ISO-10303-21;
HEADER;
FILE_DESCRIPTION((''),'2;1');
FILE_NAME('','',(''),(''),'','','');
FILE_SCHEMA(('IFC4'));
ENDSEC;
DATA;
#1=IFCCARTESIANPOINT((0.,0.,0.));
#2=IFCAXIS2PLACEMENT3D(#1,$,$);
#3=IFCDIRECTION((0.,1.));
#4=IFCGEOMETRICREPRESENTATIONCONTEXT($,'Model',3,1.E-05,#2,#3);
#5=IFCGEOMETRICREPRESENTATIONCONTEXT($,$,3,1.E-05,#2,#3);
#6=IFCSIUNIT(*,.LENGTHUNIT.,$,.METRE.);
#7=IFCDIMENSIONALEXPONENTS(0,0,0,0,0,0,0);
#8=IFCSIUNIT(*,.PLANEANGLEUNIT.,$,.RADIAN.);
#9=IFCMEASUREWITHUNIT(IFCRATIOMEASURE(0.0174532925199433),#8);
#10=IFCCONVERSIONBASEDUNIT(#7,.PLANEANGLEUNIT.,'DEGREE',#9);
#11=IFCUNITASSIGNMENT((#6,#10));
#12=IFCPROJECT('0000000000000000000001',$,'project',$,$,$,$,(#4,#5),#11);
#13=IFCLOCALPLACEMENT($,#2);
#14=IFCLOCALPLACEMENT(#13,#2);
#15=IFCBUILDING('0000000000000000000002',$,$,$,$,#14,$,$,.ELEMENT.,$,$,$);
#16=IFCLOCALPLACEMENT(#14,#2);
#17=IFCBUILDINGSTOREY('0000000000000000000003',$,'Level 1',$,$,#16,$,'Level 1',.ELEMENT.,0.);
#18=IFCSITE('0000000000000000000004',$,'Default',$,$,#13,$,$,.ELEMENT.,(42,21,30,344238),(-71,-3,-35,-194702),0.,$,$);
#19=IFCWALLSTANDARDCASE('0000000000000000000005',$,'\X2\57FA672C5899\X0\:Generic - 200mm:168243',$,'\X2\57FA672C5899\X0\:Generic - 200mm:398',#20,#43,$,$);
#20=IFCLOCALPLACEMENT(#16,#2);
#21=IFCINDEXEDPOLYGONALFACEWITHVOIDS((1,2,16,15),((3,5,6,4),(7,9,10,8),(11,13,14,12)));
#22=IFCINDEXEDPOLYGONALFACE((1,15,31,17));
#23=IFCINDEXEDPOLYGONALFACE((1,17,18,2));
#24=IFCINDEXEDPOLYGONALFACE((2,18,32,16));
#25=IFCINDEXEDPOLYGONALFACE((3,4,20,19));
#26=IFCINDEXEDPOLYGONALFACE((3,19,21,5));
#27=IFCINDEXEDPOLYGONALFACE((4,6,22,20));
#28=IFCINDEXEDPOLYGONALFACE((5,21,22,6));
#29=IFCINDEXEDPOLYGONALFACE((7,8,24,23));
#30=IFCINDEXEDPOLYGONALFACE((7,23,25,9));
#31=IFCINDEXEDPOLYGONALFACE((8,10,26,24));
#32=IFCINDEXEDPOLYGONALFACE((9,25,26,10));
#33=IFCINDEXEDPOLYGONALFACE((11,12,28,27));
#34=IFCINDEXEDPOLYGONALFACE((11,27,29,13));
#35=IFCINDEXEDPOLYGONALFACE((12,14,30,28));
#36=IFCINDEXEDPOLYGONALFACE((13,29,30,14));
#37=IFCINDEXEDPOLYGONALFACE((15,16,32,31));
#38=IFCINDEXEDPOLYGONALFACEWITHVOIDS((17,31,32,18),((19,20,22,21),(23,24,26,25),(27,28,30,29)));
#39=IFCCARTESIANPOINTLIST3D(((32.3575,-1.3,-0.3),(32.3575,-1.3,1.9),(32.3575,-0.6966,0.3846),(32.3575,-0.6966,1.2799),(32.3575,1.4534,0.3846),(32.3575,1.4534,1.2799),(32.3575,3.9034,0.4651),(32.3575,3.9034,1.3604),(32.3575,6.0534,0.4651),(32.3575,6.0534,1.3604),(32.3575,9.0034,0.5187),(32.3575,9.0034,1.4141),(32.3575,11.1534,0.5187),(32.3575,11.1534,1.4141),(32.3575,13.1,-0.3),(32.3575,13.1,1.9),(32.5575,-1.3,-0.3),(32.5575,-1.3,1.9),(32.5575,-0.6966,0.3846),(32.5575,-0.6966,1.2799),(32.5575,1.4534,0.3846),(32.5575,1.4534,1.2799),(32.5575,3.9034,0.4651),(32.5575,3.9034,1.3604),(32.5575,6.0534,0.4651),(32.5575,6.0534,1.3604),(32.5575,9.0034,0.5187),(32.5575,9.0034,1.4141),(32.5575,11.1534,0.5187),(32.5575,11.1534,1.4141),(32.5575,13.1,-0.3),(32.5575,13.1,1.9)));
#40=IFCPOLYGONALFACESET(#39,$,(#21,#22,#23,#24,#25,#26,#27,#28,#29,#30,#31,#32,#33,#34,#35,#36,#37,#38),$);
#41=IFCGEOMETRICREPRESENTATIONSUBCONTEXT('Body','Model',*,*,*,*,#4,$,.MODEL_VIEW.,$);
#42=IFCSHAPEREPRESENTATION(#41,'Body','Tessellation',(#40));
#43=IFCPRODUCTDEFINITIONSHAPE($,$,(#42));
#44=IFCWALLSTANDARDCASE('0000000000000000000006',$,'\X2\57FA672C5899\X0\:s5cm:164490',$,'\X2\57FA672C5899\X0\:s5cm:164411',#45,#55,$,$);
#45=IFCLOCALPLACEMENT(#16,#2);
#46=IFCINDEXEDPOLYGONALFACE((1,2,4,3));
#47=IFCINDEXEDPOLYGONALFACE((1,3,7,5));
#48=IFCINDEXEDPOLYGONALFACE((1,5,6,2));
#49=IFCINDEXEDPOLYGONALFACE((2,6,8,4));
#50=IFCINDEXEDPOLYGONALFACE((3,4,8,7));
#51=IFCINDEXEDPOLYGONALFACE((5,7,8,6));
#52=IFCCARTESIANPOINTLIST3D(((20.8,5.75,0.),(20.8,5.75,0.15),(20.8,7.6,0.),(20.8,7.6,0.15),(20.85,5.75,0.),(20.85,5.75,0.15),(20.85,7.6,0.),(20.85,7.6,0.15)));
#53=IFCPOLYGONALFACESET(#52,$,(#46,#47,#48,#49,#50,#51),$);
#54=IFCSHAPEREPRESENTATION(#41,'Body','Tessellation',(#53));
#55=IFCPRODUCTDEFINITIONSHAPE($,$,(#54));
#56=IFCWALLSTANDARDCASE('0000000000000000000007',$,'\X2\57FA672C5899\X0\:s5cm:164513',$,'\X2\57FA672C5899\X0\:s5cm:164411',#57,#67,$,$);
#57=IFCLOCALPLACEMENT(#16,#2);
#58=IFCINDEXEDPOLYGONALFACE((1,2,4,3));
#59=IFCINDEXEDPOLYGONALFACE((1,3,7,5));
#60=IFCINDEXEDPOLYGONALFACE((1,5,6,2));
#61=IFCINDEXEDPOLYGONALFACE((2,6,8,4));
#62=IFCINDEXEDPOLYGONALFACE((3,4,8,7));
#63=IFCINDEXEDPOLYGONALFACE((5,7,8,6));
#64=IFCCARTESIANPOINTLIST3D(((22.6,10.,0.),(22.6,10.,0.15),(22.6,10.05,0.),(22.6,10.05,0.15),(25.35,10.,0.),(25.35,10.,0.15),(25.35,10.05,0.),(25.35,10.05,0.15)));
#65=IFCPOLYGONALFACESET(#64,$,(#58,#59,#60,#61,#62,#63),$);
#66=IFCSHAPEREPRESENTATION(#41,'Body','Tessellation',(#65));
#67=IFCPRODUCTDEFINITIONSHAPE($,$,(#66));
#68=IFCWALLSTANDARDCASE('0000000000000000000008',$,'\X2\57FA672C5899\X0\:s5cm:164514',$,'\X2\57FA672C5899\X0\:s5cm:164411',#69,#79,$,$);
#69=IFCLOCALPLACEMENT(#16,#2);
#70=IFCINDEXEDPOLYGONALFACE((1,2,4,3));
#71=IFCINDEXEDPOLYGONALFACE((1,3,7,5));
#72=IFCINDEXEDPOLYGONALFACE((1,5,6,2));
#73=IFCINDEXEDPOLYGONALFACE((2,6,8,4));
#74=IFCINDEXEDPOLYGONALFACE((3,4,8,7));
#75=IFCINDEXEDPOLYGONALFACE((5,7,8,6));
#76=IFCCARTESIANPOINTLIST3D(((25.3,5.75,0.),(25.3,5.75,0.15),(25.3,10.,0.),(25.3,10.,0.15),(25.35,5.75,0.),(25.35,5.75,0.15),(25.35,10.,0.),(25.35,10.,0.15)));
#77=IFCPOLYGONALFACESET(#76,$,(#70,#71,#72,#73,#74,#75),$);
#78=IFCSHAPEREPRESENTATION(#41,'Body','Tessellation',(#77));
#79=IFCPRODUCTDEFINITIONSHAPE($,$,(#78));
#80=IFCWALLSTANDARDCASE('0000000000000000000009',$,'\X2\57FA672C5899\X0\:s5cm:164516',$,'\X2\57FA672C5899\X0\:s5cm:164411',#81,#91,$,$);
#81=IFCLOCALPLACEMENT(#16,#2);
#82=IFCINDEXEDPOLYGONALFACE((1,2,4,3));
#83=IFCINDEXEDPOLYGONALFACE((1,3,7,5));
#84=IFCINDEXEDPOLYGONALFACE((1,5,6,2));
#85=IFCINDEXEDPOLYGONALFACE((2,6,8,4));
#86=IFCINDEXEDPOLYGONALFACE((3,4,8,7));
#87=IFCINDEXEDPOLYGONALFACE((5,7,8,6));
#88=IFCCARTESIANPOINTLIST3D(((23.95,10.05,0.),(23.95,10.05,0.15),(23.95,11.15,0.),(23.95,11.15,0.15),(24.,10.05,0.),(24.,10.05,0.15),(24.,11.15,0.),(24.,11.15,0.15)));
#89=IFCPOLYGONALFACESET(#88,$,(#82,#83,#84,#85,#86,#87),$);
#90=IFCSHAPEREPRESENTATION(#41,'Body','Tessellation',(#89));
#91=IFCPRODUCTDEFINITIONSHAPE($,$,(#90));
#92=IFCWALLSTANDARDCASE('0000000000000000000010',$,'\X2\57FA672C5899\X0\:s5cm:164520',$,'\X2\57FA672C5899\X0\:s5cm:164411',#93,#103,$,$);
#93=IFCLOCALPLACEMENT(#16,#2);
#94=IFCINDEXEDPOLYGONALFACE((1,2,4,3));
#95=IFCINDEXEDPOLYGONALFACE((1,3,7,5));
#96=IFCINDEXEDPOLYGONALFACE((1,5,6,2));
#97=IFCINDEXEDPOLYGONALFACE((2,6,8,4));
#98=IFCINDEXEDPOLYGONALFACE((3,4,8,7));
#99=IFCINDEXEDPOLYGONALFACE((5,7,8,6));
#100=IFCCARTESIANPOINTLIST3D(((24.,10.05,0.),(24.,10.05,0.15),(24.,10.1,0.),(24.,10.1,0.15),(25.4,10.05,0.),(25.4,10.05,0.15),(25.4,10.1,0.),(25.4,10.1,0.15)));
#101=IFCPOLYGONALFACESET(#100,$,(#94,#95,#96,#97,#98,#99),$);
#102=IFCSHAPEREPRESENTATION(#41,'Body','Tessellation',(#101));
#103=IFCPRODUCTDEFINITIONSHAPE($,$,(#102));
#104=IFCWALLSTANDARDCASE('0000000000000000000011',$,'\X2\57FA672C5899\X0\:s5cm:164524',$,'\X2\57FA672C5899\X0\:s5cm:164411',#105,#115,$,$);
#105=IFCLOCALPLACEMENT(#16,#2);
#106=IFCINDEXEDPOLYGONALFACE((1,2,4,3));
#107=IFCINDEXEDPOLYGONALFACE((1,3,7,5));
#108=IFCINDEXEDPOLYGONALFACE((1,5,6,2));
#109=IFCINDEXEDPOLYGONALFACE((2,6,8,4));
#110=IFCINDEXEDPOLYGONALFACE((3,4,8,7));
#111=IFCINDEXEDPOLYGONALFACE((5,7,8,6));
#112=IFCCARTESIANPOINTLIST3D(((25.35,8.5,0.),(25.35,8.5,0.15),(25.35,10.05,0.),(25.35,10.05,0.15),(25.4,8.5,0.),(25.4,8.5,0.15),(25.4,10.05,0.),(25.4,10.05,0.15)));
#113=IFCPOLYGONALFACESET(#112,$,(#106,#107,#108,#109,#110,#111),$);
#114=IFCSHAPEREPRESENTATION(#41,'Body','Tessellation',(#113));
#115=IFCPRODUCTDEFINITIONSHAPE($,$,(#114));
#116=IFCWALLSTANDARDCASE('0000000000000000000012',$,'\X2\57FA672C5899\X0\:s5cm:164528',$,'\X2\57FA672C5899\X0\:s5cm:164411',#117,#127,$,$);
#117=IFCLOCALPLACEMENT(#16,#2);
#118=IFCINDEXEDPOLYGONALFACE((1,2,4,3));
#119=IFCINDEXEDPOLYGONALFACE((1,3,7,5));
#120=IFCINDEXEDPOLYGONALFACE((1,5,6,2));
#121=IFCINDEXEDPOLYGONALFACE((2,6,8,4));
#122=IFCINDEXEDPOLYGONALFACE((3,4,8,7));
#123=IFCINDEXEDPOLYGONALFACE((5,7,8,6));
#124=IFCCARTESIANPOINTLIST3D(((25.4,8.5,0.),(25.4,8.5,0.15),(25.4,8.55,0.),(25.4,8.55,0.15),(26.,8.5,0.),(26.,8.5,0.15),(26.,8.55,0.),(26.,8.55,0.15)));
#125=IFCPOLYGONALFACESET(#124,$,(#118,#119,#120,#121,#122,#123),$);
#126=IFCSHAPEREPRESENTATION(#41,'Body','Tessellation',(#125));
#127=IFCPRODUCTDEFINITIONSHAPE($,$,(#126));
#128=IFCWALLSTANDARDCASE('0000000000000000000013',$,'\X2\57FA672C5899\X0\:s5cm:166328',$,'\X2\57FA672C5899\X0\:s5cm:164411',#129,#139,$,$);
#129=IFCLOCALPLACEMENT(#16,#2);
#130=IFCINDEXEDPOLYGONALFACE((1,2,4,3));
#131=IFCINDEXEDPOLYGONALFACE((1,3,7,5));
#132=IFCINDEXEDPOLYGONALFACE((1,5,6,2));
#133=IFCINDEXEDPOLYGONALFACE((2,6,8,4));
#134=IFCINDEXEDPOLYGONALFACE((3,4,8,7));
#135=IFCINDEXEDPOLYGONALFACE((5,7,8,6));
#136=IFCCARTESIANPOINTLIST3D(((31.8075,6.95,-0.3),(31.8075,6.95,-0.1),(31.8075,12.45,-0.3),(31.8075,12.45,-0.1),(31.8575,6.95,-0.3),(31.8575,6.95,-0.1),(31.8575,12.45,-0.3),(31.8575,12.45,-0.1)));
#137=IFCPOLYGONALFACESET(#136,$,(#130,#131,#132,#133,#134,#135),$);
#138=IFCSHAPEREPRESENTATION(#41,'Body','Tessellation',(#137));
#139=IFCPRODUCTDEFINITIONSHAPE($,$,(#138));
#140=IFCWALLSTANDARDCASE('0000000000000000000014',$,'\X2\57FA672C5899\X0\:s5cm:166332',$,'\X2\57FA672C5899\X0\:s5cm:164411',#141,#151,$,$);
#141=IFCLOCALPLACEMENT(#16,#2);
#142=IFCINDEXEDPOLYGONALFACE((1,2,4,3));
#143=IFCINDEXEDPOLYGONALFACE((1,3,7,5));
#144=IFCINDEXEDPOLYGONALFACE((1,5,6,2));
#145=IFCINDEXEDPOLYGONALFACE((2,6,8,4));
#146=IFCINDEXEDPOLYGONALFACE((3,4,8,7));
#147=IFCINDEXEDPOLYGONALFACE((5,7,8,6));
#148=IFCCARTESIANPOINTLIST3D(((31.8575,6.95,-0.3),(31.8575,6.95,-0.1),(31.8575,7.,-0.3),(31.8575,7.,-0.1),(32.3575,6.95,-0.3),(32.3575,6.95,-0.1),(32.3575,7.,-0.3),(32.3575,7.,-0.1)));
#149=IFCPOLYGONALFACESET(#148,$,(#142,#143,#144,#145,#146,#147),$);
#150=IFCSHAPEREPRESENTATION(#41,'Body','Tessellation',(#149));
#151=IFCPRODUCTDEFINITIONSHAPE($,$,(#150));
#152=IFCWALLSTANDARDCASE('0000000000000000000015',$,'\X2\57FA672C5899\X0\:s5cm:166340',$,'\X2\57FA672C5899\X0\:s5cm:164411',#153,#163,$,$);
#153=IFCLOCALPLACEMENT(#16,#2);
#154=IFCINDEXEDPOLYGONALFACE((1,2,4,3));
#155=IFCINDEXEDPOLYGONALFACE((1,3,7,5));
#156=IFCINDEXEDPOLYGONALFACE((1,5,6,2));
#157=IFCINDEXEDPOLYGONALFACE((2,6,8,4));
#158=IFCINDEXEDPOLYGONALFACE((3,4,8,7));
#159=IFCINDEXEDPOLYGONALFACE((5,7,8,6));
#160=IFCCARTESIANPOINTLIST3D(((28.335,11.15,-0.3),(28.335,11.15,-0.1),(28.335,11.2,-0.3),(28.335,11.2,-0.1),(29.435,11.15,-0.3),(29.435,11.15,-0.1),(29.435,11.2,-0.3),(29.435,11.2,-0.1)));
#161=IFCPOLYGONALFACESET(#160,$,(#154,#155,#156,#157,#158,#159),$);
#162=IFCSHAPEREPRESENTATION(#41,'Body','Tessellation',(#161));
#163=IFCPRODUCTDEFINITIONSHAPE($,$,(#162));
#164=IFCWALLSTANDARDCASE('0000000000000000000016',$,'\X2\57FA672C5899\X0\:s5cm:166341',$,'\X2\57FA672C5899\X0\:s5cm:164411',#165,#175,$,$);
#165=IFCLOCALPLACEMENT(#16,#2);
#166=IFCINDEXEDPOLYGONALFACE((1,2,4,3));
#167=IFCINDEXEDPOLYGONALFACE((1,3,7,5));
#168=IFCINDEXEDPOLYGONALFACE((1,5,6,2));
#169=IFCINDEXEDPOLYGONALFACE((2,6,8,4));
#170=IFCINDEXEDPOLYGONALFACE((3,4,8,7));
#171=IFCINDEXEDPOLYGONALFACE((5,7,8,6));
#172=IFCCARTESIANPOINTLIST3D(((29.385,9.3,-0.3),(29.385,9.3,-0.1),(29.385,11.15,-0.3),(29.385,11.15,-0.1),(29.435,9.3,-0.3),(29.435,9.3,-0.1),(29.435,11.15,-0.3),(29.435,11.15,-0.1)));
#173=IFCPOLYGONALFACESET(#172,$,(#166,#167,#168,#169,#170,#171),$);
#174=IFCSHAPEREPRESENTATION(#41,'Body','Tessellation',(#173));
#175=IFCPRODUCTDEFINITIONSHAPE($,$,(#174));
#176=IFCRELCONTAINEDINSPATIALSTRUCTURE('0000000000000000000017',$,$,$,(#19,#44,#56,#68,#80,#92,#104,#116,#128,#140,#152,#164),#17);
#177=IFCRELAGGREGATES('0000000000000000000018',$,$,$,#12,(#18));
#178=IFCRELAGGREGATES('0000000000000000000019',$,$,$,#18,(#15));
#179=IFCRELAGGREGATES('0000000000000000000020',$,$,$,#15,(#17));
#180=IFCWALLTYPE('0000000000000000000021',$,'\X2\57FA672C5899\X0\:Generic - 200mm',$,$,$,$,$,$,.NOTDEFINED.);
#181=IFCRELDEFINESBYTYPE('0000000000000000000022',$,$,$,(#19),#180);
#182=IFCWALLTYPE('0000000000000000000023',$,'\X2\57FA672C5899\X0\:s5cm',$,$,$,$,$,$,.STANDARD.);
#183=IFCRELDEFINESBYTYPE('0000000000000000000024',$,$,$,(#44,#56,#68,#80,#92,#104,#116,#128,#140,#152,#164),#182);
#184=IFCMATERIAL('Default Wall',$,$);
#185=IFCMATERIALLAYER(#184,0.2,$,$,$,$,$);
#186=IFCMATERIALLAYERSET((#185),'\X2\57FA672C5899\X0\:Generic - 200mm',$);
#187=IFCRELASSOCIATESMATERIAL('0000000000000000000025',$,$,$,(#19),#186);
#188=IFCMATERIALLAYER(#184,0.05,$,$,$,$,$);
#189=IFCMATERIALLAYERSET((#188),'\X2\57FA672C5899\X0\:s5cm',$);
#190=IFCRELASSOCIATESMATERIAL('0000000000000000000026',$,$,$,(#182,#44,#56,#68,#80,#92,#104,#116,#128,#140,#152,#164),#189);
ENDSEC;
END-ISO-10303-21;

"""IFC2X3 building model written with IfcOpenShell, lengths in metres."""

from ifc_helpers import new_model, entity, si_unit, converted_unit, direction, frame, frame_2d, origin, place, context, subcontext, project, spatial, rectangle, extrude, material, layer, layer_set, layer_usage, type_object, element, save


model = new_model("IFC2X3")

# Units and contexts
model_context = context("Model", 3, precision=1e-05, world=origin(), true_north=direction((0.0, 1.0)))
context_of_model = context(None, 3, precision=1e-05, world=origin(), true_north=direction((0.0, 1.0)))
body_context = subcontext(model_context, "Body", "Model", "MODEL_VIEW")
ifc_project = project(units=[si_unit("LENGTHUNIT", "METRE"), converted_unit("PLANEANGLEUNIT", "DEGREE", entity("IfcRatioMeasure", 0.0174532925199433), si_unit("PLANEANGLEUNIT", "RADIAN"), dimensions=[0, 0, 0, 0, 0, 0, 0])], contexts=[model_context, context_of_model])

# Site, building, storey
site_placement = place(None, origin())
site = spatial("IfcSite", under=ifc_project, at=site_placement, Name="Default", CompositionType="ELEMENT", RefLatitude=(42, 21, 30, 344238), RefLongitude=(-71, -3, -35, -194702), RefElevation=0.0)
building_placement = place(site_placement, origin())
building = spatial("IfcBuilding", under=site, at=building_placement, CompositionType="ELEMENT")
storey_placement = place(building_placement, origin())
storey = spatial("IfcBuildingStorey", under=building, at=storey_placement, Name="Level 1", LongName="Level 1", CompositionType="ELEMENT", Elevation=0.0)

# Wall, openings
ifc_material = material(Name="Default Wall")
ifc_layer_1 = layer(ifc_material, 0.2)
ifc_layer_set_1 = layer_set([ifc_layer_1], Name="基本墙:Generic - 200mm")
ifc_layer_usage_1 = layer_usage(ifc_layer_set_1, "AXIS2", "NEGATIVE", 0.1)
wall_type_1 = type_object("IfcWallType", Name="基本墙:Generic - 200mm", PredefinedType="NOTDEFINED")
wall_1_placement = place(storey_placement, frame((32.4575, 13.1, -0.3), z_axis=(0.0, 0.0, 1.0), x_axis=(0.0, -1.0, 0.0)))
wall_1 = element("IfcWallStandardCase", 1, at=wall_1_placement, inside=storey, type_object=wall_type_1, material=ifc_layer_usage_1, Name="基本墙:Generic - 200mm:168243", ObjectType="基本墙:Generic - 200mm:398", context=body_context, shape_type="SweptSolid", body=[
    extrude(rectangle(XDim=14.4, YDim=0.2, at=frame_2d((7.2, 0.0), x_axis=(-1.0, 0.0))), origin(), (0.0, 0.0, 1.0), 2.2),
])
opening_1_placement = place(wall_1_placement, frame((13.7966, -0.2048, 0.6846)))
element("IfcOpeningElement", 2, at=opening_1_placement, cuts=wall_1, ObjectType="Opening", context=body_context, shape_type="SweptSolid", body=[
    extrude(rectangle(XDim=0.8953, YDim=2.15, at=frame_2d((0.0, 0.0), x_axis=(0.0, 1.0))), frame((-1.075, 0.0, 0.4477), z_axis=(0.0, 1.0, 0.0), x_axis=(1.0, 0.0, 0.0)), (0.0, 0.0, 1.0), 0.3048),
])
opening_2_placement = place(wall_1_placement, frame((9.1966, -0.2048, 0.7651)))
element("IfcOpeningElement", 3, at=opening_2_placement, cuts=wall_1, ObjectType="Opening", context=body_context, shape_type="SweptSolid", body=[
    extrude(rectangle(XDim=0.8953, YDim=2.15, at=frame_2d((0.0, 0.0), x_axis=(0.0, 1.0))), frame((-1.075, 0.0, 0.4477), z_axis=(0.0, 1.0, 0.0), x_axis=(1.0, 0.0, 0.0)), (0.0, 0.0, 1.0), 0.3048),
])
opening_3_placement = place(wall_1_placement, frame((4.0966, -0.2048, 0.8187)))
element("IfcOpeningElement", 4, at=opening_3_placement, cuts=wall_1, ObjectType="Opening", context=body_context, shape_type="SweptSolid", body=[
    extrude(rectangle(XDim=0.8953, YDim=2.15, at=frame_2d((0.0, 0.0), x_axis=(0.0, 1.0))), frame((-1.075, 0.0, 0.4477), z_axis=(0.0, 1.0, 0.0), x_axis=(1.0, 0.0, 0.0)), (0.0, 0.0, 1.0), 0.3048),
])

# Walls
ifc_layer_2 = layer(ifc_material, 0.05)
ifc_layer_set_2 = layer_set([ifc_layer_2], Name="基本墙:s5cm")
ifc_layer_usage_2 = layer_usage(ifc_layer_set_2, "AXIS2", "NEGATIVE", 0.025)
wall_type_2 = type_object("IfcWallType", Name="基本墙:s5cm", PredefinedType="STANDARD", material=ifc_layer_set_2)
wall_2_placement = place(storey_placement, frame((20.825, 7.6, 0.0), z_axis=(0.0, 0.0, 1.0), x_axis=(0.0, -1.0, 0.0)))
element("IfcWallStandardCase", 5, at=wall_2_placement, inside=storey, type_object=wall_type_2, material=ifc_layer_usage_2, Name="基本墙:s5cm:164490", ObjectType="基本墙:s5cm:164411", context=body_context, shape_type="SweptSolid", body=[
    extrude(rectangle(XDim=1.85, YDim=0.05, at=frame_2d((0.925, 0.0), x_axis=(-1.0, 0.0))), origin(), (0.0, 0.0, 1.0), 0.15),
])
ifc_layer_usage_3 = layer_usage(ifc_layer_set_2, "AXIS2", "NEGATIVE", 0.025)
wall_3_placement = place(storey_placement, frame((22.6, 10.025, 0.0)))
element("IfcWallStandardCase", 6, at=wall_3_placement, inside=storey, type_object=wall_type_2, material=ifc_layer_usage_3, Name="基本墙:s5cm:164513", ObjectType="基本墙:s5cm:164411", context=body_context, shape_type="SweptSolid", body=[
    extrude(rectangle(XDim=2.75, YDim=0.05, at=frame_2d((1.375, 0.0), x_axis=(-1.0, 0.0))), origin(), (0.0, 0.0, 1.0), 0.15),
])
ifc_layer_usage_4 = layer_usage(ifc_layer_set_2, "AXIS2", "NEGATIVE", 0.025)
wall_4_placement = place(storey_placement, frame((25.325, 10.0, 0.0), z_axis=(0.0, 0.0, 1.0), x_axis=(0.0, -1.0, 0.0)))
element("IfcWallStandardCase", 7, at=wall_4_placement, inside=storey, type_object=wall_type_2, material=ifc_layer_usage_4, Name="基本墙:s5cm:164514", ObjectType="基本墙:s5cm:164411", context=body_context, shape_type="SweptSolid", body=[
    extrude(rectangle(XDim=4.25, YDim=0.05, at=frame_2d((2.125, 0.0), x_axis=(-1.0, 0.0))), origin(), (0.0, 0.0, 1.0), 0.15),
])
ifc_layer_usage_5 = layer_usage(ifc_layer_set_2, "AXIS2", "NEGATIVE", 0.025)
wall_5_placement = place(storey_placement, frame((23.975, 10.05, 0.0), z_axis=(0.0, 0.0, 1.0), x_axis=(0.0, 1.0, 0.0)))
element("IfcWallStandardCase", 8, at=wall_5_placement, inside=storey, type_object=wall_type_2, material=ifc_layer_usage_5, Name="基本墙:s5cm:164516", ObjectType="基本墙:s5cm:164411", context=body_context, shape_type="SweptSolid", body=[
    extrude(rectangle(XDim=1.1, YDim=0.05, at=frame_2d((0.55, 0.0), x_axis=(-1.0, 0.0))), origin(), (0.0, 0.0, 1.0), 0.15),
])
ifc_layer_usage_6 = layer_usage(ifc_layer_set_2, "AXIS2", "NEGATIVE", 0.025)
wall_6_placement = place(storey_placement, frame((24.0, 10.075, 0.0)))
element("IfcWallStandardCase", 9, at=wall_6_placement, inside=storey, type_object=wall_type_2, material=ifc_layer_usage_6, Name="基本墙:s5cm:164520", ObjectType="基本墙:s5cm:164411", context=body_context, shape_type="SweptSolid", body=[
    extrude(rectangle(XDim=1.4, YDim=0.05, at=frame_2d((0.7, 0.0), x_axis=(-1.0, 0.0))), origin(), (0.0, 0.0, 1.0), 0.15),
])
ifc_layer_usage_7 = layer_usage(ifc_layer_set_2, "AXIS2", "NEGATIVE", 0.025)
wall_7_placement = place(storey_placement, frame((25.375, 10.05, 0.0), z_axis=(0.0, 0.0, 1.0), x_axis=(0.0, -1.0, 0.0)))
element("IfcWallStandardCase", 10, at=wall_7_placement, inside=storey, type_object=wall_type_2, material=ifc_layer_usage_7, Name="基本墙:s5cm:164524", ObjectType="基本墙:s5cm:164411", context=body_context, shape_type="SweptSolid", body=[
    extrude(rectangle(XDim=1.55, YDim=0.05, at=frame_2d((0.775, 0.0), x_axis=(-1.0, 0.0))), origin(), (0.0, 0.0, 1.0), 0.15),
])
ifc_layer_usage_8 = layer_usage(ifc_layer_set_2, "AXIS2", "NEGATIVE", 0.025)
wall_8_placement = place(storey_placement, frame((26.0, 8.525, 0.0), z_axis=(0.0, 0.0, 1.0), x_axis=(-1.0, 0.0, 0.0)))
element("IfcWallStandardCase", 11, at=wall_8_placement, inside=storey, type_object=wall_type_2, material=ifc_layer_usage_8, Name="基本墙:s5cm:164528", ObjectType="基本墙:s5cm:164411", context=body_context, shape_type="SweptSolid", body=[
    extrude(rectangle(XDim=0.6, YDim=0.05, at=frame_2d((0.3, 0.0), x_axis=(-1.0, 0.0))), origin(), (0.0, 0.0, 1.0), 0.15),
])
ifc_layer_usage_9 = layer_usage(ifc_layer_set_2, "AXIS2", "NEGATIVE", 0.025)
wall_9_placement = place(storey_placement, frame((31.8325, 12.45, -0.3), z_axis=(0.0, 0.0, 1.0), x_axis=(0.0, -1.0, 0.0)))
element("IfcWallStandardCase", 12, at=wall_9_placement, inside=storey, type_object=wall_type_2, material=ifc_layer_usage_9, Name="基本墙:s5cm:166328", ObjectType="基本墙:s5cm:164411", context=body_context, shape_type="SweptSolid", body=[
    extrude(rectangle(XDim=5.5, YDim=0.05, at=frame_2d((2.75, 0.0), x_axis=(-1.0, 0.0))), origin(), (0.0, 0.0, 1.0), 0.2),
])
ifc_layer_usage_10 = layer_usage(ifc_layer_set_2, "AXIS2", "POSITIVE", -0.025)
wall_10_placement = place(storey_placement, frame((31.8575, 6.975, -0.3)))
element("IfcWallStandardCase", 13, at=wall_10_placement, inside=storey, type_object=wall_type_2, material=ifc_layer_usage_10, Name="基本墙:s5cm:166332", ObjectType="基本墙:s5cm:164411", context=body_context, shape_type="SweptSolid", body=[
    extrude(rectangle(XDim=0.5, YDim=0.05, at=frame_2d((0.25, 0.0), x_axis=(-1.0, 0.0))), origin(), (0.0, 0.0, 1.0), 0.2),
])
ifc_layer_usage_11 = layer_usage(ifc_layer_set_2, "AXIS2", "POSITIVE", -0.025)
wall_11_placement = place(storey_placement, frame((28.335, 11.175, -0.3)))
element("IfcWallStandardCase", 14, at=wall_11_placement, inside=storey, type_object=wall_type_2, material=ifc_layer_usage_11, Name="基本墙:s5cm:166340", ObjectType="基本墙:s5cm:164411", context=body_context, shape_type="SweptSolid", body=[
    extrude(rectangle(XDim=1.1, YDim=0.05, at=frame_2d((0.55, 0.0), x_axis=(-1.0, 0.0))), origin(), (0.0, 0.0, 1.0), 0.2),
])
ifc_layer_usage_12 = layer_usage(ifc_layer_set_2, "AXIS2", "POSITIVE", -0.025)
wall_12_placement = place(storey_placement, frame((29.41, 11.15, -0.3), z_axis=(0.0, 0.0, 1.0), x_axis=(0.0, -1.0, 0.0)))
element("IfcWallStandardCase", 15, at=wall_12_placement, inside=storey, type_object=wall_type_2, material=ifc_layer_usage_12, Name="基本墙:s5cm:166341", ObjectType="基本墙:s5cm:164411", context=body_context, shape_type="SweptSolid", body=[
    extrude(rectangle(XDim=1.85, YDim=0.05, at=frame_2d((0.925, 0.0), x_axis=(-1.0, 0.0))), origin(), (0.0, 0.0, 1.0), 0.2),
])

save(model, "model.ifc")
